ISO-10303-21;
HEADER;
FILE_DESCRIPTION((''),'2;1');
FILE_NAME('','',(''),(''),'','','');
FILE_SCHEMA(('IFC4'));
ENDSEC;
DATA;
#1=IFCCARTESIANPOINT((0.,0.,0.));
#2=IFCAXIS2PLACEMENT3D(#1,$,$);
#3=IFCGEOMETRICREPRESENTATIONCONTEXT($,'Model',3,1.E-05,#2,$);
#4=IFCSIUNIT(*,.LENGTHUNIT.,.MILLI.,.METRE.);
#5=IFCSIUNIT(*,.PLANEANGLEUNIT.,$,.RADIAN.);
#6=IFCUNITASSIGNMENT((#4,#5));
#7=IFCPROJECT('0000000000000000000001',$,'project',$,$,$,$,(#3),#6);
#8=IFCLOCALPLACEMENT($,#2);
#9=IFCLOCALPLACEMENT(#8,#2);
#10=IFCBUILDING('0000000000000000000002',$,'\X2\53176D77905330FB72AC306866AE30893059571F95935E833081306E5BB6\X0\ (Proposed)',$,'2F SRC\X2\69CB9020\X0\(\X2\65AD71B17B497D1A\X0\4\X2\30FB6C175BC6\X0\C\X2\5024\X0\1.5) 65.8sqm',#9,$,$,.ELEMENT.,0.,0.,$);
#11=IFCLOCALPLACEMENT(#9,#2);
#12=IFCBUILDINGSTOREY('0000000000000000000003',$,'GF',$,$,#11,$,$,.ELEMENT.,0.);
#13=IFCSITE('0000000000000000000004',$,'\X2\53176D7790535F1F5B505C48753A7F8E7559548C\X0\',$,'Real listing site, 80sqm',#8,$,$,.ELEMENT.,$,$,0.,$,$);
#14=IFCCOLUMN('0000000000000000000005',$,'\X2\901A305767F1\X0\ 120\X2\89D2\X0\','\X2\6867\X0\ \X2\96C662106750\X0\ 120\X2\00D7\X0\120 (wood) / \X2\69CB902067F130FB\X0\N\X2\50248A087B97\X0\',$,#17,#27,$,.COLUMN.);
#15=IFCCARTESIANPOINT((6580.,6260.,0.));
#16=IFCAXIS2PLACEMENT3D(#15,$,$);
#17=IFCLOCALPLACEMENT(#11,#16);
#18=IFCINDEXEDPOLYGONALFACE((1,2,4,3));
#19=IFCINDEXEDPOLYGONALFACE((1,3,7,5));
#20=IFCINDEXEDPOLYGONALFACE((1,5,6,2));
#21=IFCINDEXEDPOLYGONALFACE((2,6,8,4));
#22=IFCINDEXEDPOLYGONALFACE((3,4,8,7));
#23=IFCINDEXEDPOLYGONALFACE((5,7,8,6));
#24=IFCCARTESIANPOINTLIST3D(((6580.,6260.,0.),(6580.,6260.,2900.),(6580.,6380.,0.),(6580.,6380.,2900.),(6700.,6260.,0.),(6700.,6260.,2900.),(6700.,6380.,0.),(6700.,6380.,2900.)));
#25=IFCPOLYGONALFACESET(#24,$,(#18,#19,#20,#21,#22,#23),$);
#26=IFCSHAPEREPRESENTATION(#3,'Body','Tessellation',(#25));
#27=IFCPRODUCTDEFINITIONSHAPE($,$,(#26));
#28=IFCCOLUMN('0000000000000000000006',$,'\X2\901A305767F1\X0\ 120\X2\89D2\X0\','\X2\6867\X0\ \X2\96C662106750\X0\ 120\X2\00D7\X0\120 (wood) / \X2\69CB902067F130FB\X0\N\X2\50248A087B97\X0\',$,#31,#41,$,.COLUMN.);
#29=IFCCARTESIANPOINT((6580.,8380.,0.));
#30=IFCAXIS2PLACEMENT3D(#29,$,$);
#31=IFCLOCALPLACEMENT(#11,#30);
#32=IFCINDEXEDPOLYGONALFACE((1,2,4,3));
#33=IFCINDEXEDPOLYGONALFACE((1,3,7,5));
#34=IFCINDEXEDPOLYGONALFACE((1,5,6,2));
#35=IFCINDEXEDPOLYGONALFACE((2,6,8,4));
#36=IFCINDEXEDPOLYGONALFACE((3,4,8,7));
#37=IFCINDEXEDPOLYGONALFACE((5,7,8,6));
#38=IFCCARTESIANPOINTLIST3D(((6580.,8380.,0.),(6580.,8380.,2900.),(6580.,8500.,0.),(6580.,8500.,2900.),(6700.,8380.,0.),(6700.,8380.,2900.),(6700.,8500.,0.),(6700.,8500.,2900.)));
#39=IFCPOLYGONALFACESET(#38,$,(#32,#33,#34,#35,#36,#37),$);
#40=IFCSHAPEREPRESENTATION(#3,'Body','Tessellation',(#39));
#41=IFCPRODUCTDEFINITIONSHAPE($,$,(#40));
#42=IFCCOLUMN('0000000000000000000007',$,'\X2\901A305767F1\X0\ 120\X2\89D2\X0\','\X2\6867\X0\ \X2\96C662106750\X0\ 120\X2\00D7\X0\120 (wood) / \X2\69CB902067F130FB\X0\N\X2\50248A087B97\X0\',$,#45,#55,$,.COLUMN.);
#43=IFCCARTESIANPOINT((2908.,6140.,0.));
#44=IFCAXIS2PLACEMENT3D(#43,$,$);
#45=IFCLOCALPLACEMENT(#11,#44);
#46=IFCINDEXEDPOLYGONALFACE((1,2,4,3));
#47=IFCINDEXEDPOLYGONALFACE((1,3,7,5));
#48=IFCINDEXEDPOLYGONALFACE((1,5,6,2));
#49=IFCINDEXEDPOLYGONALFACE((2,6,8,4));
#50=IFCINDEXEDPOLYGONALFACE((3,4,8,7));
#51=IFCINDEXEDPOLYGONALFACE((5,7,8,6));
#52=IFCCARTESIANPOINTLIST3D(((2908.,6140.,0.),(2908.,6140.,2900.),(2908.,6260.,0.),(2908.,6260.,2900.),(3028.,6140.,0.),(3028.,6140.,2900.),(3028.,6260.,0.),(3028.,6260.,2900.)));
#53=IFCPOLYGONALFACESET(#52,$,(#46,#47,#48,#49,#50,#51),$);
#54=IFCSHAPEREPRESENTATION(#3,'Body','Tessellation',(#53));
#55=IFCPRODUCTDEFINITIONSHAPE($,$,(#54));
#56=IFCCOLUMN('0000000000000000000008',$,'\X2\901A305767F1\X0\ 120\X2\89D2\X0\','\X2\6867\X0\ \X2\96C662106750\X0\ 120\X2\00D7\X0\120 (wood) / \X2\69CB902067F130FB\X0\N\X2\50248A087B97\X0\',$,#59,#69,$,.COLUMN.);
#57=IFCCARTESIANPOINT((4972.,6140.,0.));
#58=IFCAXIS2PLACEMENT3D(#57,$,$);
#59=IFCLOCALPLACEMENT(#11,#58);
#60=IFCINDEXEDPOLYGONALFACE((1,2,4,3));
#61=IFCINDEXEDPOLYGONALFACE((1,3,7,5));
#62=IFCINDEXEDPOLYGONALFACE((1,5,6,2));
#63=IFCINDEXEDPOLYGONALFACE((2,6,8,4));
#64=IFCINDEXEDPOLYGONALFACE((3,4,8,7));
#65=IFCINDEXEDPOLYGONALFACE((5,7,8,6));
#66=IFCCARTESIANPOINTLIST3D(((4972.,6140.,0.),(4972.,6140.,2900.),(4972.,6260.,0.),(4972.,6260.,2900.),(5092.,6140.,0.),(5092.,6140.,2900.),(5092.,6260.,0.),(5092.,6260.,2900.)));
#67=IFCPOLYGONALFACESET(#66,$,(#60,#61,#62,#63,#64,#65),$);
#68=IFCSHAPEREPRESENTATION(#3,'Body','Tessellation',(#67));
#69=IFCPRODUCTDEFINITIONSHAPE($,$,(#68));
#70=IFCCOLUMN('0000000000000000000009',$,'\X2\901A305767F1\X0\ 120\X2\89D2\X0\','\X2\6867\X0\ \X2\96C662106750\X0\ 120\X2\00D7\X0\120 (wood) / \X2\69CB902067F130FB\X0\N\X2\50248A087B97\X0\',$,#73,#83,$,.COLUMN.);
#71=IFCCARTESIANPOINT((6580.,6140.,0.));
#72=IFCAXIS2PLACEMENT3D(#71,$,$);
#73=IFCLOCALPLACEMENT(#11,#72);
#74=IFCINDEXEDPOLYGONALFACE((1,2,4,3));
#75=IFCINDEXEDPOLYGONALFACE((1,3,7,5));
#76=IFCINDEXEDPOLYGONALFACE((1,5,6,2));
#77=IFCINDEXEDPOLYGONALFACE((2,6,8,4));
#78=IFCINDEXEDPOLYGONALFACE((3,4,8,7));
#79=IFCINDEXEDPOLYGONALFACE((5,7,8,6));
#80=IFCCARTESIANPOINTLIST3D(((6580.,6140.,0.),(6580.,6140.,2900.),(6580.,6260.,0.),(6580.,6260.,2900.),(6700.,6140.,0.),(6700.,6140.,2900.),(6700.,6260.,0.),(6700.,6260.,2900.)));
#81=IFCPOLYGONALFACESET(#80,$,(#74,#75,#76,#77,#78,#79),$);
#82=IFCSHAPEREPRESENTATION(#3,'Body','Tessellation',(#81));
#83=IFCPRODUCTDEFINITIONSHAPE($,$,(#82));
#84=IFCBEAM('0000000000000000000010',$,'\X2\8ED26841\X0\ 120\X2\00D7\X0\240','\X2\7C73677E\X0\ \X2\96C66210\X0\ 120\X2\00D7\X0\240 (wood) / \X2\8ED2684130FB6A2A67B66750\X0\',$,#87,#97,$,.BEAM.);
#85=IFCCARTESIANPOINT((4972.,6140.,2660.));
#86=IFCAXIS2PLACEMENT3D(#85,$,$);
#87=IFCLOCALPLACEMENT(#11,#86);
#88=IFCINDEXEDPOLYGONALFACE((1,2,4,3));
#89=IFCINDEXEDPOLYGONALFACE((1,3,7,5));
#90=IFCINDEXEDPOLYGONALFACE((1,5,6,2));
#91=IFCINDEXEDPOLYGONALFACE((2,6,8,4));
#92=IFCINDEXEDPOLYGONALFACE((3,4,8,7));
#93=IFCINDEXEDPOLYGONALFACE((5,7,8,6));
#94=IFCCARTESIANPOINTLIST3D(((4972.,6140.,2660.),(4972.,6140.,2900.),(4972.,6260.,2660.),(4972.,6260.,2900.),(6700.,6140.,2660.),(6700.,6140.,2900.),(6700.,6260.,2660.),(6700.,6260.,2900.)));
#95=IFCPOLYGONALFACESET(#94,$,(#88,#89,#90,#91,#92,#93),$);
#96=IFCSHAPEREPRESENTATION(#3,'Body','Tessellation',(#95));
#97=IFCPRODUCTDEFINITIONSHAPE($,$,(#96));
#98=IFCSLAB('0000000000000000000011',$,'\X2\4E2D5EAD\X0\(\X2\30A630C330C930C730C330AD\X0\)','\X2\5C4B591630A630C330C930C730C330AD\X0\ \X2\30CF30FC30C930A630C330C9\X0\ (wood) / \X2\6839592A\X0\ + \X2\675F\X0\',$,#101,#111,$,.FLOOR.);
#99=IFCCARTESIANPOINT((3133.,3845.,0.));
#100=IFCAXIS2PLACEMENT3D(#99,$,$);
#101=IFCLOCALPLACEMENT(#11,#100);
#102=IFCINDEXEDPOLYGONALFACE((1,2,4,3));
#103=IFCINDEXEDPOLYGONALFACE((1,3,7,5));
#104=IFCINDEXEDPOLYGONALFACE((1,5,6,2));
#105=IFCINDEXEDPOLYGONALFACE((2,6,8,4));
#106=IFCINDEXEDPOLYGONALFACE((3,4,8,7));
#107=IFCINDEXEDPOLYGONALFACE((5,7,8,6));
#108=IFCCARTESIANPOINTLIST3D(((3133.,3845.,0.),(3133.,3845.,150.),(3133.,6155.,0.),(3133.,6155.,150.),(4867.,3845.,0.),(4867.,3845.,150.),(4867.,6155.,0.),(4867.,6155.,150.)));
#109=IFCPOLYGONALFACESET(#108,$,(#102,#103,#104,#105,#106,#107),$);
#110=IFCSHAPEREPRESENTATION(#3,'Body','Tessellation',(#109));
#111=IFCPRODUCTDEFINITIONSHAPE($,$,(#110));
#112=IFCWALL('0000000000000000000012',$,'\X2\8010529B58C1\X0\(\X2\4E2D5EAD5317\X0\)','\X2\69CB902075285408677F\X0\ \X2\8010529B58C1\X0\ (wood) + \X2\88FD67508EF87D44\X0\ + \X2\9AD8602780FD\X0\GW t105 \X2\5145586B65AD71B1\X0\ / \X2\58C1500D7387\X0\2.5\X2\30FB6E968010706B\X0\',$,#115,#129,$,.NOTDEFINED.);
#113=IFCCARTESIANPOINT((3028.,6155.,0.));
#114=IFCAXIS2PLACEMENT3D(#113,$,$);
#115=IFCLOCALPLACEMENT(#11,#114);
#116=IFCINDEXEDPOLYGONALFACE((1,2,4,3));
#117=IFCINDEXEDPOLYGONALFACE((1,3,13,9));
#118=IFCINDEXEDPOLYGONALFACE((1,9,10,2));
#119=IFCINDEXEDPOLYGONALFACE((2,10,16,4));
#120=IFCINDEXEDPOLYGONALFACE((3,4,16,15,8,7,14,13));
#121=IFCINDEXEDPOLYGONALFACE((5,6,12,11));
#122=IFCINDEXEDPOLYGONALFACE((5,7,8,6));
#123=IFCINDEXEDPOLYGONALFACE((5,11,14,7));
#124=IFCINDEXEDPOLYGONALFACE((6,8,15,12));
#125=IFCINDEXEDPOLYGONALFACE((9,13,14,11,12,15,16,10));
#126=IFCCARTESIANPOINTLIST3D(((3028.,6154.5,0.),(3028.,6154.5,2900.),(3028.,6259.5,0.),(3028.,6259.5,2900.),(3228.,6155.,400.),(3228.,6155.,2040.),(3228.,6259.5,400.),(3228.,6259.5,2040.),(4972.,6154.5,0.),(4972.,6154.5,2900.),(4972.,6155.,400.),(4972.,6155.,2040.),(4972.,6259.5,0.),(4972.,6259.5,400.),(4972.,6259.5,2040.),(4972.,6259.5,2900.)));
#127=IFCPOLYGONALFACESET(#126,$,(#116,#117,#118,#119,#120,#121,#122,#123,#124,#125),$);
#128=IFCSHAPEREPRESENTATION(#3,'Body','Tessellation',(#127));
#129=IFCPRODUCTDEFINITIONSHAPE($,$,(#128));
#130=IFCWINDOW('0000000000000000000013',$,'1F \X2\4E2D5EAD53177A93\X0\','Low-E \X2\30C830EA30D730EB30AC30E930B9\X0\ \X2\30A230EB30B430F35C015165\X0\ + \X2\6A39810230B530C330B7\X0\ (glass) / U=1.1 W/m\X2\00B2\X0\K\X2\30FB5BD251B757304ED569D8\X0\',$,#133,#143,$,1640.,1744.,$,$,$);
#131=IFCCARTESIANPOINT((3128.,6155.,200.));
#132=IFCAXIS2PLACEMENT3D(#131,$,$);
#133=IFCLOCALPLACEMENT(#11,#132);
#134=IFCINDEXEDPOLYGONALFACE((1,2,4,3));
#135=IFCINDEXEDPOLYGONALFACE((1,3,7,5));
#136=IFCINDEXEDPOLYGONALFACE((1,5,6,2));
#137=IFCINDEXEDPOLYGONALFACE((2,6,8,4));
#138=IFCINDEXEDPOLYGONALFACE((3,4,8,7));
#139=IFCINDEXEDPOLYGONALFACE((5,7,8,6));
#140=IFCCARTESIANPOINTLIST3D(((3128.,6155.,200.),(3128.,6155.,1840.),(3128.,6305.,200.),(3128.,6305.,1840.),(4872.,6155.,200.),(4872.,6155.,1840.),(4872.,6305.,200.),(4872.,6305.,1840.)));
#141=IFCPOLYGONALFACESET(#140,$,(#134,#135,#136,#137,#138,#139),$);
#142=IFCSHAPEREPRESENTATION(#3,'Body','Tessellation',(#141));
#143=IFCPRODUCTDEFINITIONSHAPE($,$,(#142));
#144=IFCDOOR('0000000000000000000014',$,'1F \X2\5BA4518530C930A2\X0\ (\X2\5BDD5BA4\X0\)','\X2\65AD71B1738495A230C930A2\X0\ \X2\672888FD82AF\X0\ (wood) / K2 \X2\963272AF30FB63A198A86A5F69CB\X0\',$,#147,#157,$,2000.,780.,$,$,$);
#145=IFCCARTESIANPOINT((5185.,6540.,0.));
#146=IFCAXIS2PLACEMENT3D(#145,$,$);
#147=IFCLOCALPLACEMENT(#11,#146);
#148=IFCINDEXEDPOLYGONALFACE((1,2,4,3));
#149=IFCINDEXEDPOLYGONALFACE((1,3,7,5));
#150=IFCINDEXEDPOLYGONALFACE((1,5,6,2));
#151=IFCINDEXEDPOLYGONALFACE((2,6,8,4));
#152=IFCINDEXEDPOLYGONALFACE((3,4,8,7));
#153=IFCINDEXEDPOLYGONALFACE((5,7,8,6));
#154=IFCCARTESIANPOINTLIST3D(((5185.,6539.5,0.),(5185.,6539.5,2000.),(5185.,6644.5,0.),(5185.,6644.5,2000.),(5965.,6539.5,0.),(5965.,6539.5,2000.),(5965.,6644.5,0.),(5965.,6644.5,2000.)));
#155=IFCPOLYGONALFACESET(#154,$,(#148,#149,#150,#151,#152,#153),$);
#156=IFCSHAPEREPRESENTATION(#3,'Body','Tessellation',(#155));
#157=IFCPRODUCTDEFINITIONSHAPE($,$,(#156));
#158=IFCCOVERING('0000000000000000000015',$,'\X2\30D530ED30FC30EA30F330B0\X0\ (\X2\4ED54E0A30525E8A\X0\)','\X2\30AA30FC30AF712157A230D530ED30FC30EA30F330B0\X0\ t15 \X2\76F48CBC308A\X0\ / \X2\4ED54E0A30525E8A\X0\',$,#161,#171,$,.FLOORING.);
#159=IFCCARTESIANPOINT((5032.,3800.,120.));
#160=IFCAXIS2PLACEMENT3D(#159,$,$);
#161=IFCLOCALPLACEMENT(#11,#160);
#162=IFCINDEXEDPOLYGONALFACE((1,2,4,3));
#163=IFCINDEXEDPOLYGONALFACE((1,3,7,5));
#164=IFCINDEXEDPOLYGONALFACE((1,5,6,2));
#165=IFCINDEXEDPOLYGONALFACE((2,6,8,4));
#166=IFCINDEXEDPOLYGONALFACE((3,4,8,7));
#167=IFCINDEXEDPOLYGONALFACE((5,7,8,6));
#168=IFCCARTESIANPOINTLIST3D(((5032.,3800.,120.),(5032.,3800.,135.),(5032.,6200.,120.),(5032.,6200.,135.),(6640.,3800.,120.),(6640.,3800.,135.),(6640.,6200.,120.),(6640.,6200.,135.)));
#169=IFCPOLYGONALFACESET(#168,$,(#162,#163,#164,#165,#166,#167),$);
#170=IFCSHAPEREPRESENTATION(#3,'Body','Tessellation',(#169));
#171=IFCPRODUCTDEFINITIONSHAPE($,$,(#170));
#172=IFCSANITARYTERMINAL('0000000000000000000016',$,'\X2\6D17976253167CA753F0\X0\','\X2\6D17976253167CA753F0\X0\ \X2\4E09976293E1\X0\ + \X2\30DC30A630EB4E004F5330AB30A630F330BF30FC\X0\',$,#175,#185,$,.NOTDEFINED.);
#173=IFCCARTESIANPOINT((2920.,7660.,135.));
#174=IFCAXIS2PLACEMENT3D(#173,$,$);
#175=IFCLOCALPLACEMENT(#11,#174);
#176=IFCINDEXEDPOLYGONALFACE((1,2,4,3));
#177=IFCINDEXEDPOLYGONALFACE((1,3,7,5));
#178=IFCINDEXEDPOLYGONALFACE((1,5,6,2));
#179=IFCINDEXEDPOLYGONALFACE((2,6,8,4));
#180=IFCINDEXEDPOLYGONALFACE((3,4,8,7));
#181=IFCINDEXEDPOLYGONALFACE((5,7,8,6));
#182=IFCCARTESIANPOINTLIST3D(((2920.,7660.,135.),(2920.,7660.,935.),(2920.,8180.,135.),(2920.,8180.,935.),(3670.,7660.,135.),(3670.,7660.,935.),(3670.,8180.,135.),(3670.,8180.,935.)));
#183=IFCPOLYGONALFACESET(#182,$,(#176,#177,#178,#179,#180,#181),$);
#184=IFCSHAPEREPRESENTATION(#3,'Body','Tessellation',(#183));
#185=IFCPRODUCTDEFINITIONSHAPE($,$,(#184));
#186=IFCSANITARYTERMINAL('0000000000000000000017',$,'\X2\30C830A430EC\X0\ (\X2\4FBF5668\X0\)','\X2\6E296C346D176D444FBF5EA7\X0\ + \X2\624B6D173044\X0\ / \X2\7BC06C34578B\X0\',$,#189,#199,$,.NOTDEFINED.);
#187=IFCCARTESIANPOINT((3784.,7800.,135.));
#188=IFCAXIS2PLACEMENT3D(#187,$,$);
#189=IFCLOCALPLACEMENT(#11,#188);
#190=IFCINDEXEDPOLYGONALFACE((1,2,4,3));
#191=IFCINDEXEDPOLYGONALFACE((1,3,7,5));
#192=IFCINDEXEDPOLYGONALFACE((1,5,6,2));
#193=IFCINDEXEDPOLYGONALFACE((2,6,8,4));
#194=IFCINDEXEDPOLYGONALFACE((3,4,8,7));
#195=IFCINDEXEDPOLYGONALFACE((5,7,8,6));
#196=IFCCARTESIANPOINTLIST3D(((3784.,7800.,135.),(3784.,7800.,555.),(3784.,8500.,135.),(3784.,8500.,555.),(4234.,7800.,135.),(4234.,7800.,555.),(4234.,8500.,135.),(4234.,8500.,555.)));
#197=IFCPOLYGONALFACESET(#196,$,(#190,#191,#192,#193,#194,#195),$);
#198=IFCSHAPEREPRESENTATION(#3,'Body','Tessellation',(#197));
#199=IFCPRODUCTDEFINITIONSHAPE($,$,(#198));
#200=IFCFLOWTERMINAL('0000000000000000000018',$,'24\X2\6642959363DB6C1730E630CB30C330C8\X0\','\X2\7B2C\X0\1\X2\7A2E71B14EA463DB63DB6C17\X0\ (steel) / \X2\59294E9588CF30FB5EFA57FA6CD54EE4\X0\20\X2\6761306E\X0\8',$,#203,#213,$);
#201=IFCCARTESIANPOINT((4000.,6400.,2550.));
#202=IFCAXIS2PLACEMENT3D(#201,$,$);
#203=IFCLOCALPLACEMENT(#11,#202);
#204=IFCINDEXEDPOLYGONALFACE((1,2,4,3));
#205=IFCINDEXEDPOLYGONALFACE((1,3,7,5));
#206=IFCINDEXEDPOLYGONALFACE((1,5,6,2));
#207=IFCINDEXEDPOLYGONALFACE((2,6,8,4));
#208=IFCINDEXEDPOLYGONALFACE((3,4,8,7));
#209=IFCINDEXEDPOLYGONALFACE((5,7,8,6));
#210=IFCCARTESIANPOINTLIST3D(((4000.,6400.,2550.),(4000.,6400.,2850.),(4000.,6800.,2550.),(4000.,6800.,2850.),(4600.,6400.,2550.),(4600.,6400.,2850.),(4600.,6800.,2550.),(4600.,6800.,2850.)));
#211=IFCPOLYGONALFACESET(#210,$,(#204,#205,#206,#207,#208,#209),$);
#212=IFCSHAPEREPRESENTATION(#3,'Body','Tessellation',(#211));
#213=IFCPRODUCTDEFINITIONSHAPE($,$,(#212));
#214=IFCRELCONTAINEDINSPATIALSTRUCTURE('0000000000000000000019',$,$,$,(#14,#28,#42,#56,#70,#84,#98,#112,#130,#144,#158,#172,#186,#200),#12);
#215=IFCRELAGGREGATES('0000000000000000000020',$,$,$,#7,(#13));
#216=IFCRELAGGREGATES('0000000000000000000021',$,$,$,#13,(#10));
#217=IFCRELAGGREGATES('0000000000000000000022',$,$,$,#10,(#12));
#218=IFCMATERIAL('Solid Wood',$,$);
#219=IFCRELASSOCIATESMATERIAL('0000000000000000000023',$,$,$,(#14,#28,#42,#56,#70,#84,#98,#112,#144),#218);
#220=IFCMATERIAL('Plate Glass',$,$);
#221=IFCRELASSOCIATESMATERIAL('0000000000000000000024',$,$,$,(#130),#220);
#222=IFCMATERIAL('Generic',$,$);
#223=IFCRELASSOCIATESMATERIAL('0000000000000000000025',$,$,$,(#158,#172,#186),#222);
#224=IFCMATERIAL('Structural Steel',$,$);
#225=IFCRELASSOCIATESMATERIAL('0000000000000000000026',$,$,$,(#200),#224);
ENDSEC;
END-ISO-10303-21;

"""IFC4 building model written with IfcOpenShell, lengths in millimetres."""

from ifc_helpers import new_model, si_unit, frame, frame_2d, origin, place, context, project, spatial, rectangle, extrude, material, element, fill, save


model = new_model("IFC4")

# Units and contexts
model_context = context("Model", 3, precision=1e-05, world=origin())
ifc_project = project(units=[si_unit("LENGTHUNIT", "METRE", prefix="MILLI"), si_unit("PLANEANGLEUNIT", "RADIAN")], contexts=[model_context])

# Site, building, storey
site_placement = place(None, origin())
site = spatial("IfcSite", under=ifc_project, at=site_placement, Name="北海道弟子屈町美留和", ObjectType="Real listing site, 80sqm", CompositionType="ELEMENT", RefElevation=0.0)
building_placement = place(site_placement, origin())
building = spatial("IfcBuilding", under=site, at=building_placement, Name="北海道・犬と暮らす土間広めの家 (Proposed)", ObjectType="2F SRC構造(断熱等級4・気密C値1.5) 65.8sqm", CompositionType="ELEMENT", ElevationOfRefHeight=0.0, ElevationOfTerrain=0.0)
storey_placement = place(building_placement, origin())
storey = spatial("IfcBuildingStorey", under=building, at=storey_placement, Name="GF", CompositionType="ELEMENT", Elevation=0.0)

# Columns
ifc_material_1 = material(Name="Solid Wood")
column_1_placement = place(storey_placement, frame((6580.0, 6260.0, 0.0)))
element("IfcColumn", 1, at=column_1_placement, inside=storey, material=ifc_material_1, Name="通し柱 120角", Description="桧 集成材 120×120 (wood) / 構造柱・N値計算", PredefinedType="COLUMN", context=model_context, shape_type="SweptSolid", body=[
    extrude(rectangle(XDim=120.0, YDim=120.0, at=frame_2d((60.0, 60.0))), frame((6580.0, 6260.0, 0.0)), (0.0, 0.0, 1.0), 2900.0),
])
column_2_placement = place(storey_placement, frame((6580.0, 8380.0, 0.0)))
element("IfcColumn", 2, at=column_2_placement, inside=storey, material=ifc_material_1, Name="通し柱 120角", Description="桧 集成材 120×120 (wood) / 構造柱・N値計算", PredefinedType="COLUMN", context=model_context, shape_type="SweptSolid", body=[
    extrude(rectangle(XDim=120.0, YDim=120.0, at=frame_2d((60.0, 60.0))), frame((6580.0, 8380.0, 0.0)), (0.0, 0.0, 1.0), 2900.0),
])
column_3_placement = place(storey_placement, frame((2908.0, 6140.0, 0.0)))
element("IfcColumn", 3, at=column_3_placement, inside=storey, material=ifc_material_1, Name="通し柱 120角", Description="桧 集成材 120×120 (wood) / 構造柱・N値計算", PredefinedType="COLUMN", context=model_context, shape_type="SweptSolid", body=[
    extrude(rectangle(XDim=120.0, YDim=120.0, at=frame_2d((60.0, 60.0))), frame((2908.0, 6140.0, 0.0)), (0.0, 0.0, 1.0), 2900.0),
])
column_4_placement = place(storey_placement, frame((4972.0, 6140.0, 0.0)))
element("IfcColumn", 4, at=column_4_placement, inside=storey, material=ifc_material_1, Name="通し柱 120角", Description="桧 集成材 120×120 (wood) / 構造柱・N値計算", PredefinedType="COLUMN", context=model_context, shape_type="SweptSolid", body=[
    extrude(rectangle(XDim=120.0, YDim=120.0, at=frame_2d((60.0, 60.0))), frame((4972.0, 6140.0, 0.0)), (0.0, 0.0, 1.0), 2900.0),
])
column_5_placement = place(storey_placement, frame((6580.0, 6140.0, 0.0)))
element("IfcColumn", 5, at=column_5_placement, inside=storey, material=ifc_material_1, Name="通し柱 120角", Description="桧 集成材 120×120 (wood) / 構造柱・N値計算", PredefinedType="COLUMN", context=model_context, shape_type="SweptSolid", body=[
    extrude(rectangle(XDim=120.0, YDim=120.0, at=frame_2d((60.0, 60.0))), frame((6580.0, 6140.0, 0.0)), (0.0, 0.0, 1.0), 2900.0),
])

# Beam
beam_1_placement = place(storey_placement, frame((4972.0, 6140.0, 2660.0)))
element("IfcBeam", 6, at=beam_1_placement, inside=storey, material=ifc_material_1, Name="軒桁 120×240", Description="米松 集成 120×240 (wood) / 軒桁・横架材", PredefinedType="BEAM", context=model_context, shape_type="SweptSolid", body=[
    extrude(rectangle(XDim=1728.0, YDim=120.0, at=frame_2d((864.0, 60.0))), frame((4972.0, 6140.0, 2660.0)), (0.0, 0.0, 1.0), 240.0),
])

# Slab
slab_placement = place(storey_placement, frame((3133.0, 3845.0, 0.0)))
element("IfcSlab", 7, at=slab_placement, inside=storey, material=ifc_material_1, Name="中庭(ウッドデッキ)", Description="屋外ウッドデッキ ハードウッド (wood) / 根太 + 束", PredefinedType="FLOOR", context=model_context, shape_type="SweptSolid", body=[
    extrude(rectangle(XDim=1734.0, YDim=2310.0, at=frame_2d((867.0, 1155.0))), frame((3133.0, 3845.0, 0.0)), (0.0, 0.0, 1.0), 150.0),
])

# Wall, opening, window
wall_1_placement = place(storey_placement, frame((3028.0, 6155.0, 0.0)))
wall_1 = element("IfcWall", 8, at=wall_1_placement, inside=storey, material=ifc_material_1, Name="耐力壁(中庭北)", Description="構造用合板 耐力壁 (wood) + 製材軸組 + 高性能GW t105 充填断熱 / 壁倍率2.5・準耐火", PredefinedType="NOTDEFINED", context=model_context, shape_type="SweptSolid", body=[
    extrude(rectangle(XDim=1944.0, YDim=105.0, at=frame_2d((972.0, 52.0))), frame((3028.0, 6155.0, 0.0)), (0.0, 0.0, 1.0), 2900.0),
])
opening_placement = place(storey_placement, frame((3128.0, 6155.0, 200.0)))
opening = element("IfcOpeningElement", 9, at=opening_placement, cuts=wall_1, PredefinedType="NOTDEFINED", context=model_context, shape_type="SweptSolid", body=[
    extrude(rectangle(XDim=1744.0, YDim=150.0, at=frame_2d((872.0, 75.0))), frame((3128.0, 6155.0, 200.0)), (0.0, 0.0, 1.0), 1640.0),
])
ifc_material_2 = material(Name="Plate Glass")
window_placement = place(storey_placement, frame((3128.0, 6155.0, 200.0)))
window = element("IfcWindow", 10, at=window_placement, inside=storey, material=ifc_material_2, Name="1F 中庭北窓", Description="Low-E トリプルガラス アルゴン封入 + 樹脂サッシ (glass) / U=1.1 W/m²K・寒冷地仕様", OverallHeight=1640.0, OverallWidth=1744.0, context=model_context, shape_type="SweptSolid", body=[
    extrude(rectangle(XDim=1744.0, YDim=150.0, at=frame_2d((872.0, 75.0))), frame((3128.0, 6155.0, 200.0)), (0.0, 0.0, 1.0), 1640.0),
])
fill(opening, window)

# Door
door_placement = place(storey_placement, frame((5185.0, 6540.0, 0.0)))
element("IfcDoor", 11, at=door_placement, inside=storey, material=ifc_material_1, Name="1F 室内ドア (寝室)", Description="断熱玄関ドア 木製芯 (wood) / K2 防犯・採風機構", OverallHeight=2000.0, OverallWidth=780.0, context=model_context, shape_type="SweptSolid", body=[
    extrude(rectangle(XDim=780.0, YDim=105.0, at=frame_2d((390.0, 52.0))), frame((5185.0, 6540.0, 0.0)), (0.0, 0.0, 1.0), 2000.0),
])

# Covering
ifc_material_3 = material(Name="Generic")
covering_placement = place(storey_placement, frame((5032.0, 3800.0, 120.0)))
element("IfcCovering", 12, at=covering_placement, inside=storey, material=ifc_material_3, Name="フローリング (仕上げ床)", Description="オーク無垢フローリング t15 直貼り / 仕上げ床", PredefinedType="FLOORING", context=model_context, shape_type="SweptSolid", body=[
    extrude(rectangle(XDim=1608.0, YDim=2400.0, at=frame_2d((804.0, 1200.0))), frame((5032.0, 3800.0, 120.0)), (0.0, 0.0, 1.0), 15.0),
])

# Sanitary terminals
sanitary_terminal_1_placement = place(storey_placement, frame((2920.0, 7660.0, 135.0)))
element("IfcSanitaryTerminal", 13, at=sanitary_terminal_1_placement, inside=storey, material=ifc_material_3, Name="洗面化粧台", Description="洗面化粧台 三面鏡 + ボウル一体カウンター", PredefinedType="NOTDEFINED", context=model_context, shape_type="SweptSolid", body=[
    extrude(rectangle(XDim=750.0, YDim=520.0, at=frame_2d((375.0, 260.0))), frame((2920.0, 7660.0, 135.0)), (0.0, 0.0, 1.0), 800.0),
])
sanitary_terminal_2_placement = place(storey_placement, frame((3784.0, 7800.0, 135.0)))
element("IfcSanitaryTerminal", 14, at=sanitary_terminal_2_placement, inside=storey, material=ifc_material_3, Name="トイレ (便器)", Description="温水洗浄便座 + 手洗い / 節水型", PredefinedType="NOTDEFINED", context=model_context, shape_type="SweptSolid", body=[
    extrude(rectangle(XDim=450.0, YDim=700.0, at=frame_2d((225.0, 350.0))), frame((3784.0, 7800.0, 135.0)), (0.0, 0.0, 1.0), 420.0),
])

# Flow terminal
ifc_material_4 = material(Name="Structural Steel")
flow_terminal_placement = place(storey_placement, frame((4000.0, 6400.0, 2550.0)))
element("IfcFlowTerminal", 15, at=flow_terminal_placement, inside=storey, material=ifc_material_4, Name="24時間換気ユニット", Description="第1種熱交換換気 (steel) / 天井裏・建基法令20条の8", context=model_context, shape_type="SweptSolid", body=[
    extrude(rectangle(XDim=600.0, YDim=400.0, at=frame_2d((300.0, 200.0))), frame((4000.0, 6400.0, 2550.0)), (0.0, 0.0, 1.0), 300.0),
])

save(model, "model.ifc")
